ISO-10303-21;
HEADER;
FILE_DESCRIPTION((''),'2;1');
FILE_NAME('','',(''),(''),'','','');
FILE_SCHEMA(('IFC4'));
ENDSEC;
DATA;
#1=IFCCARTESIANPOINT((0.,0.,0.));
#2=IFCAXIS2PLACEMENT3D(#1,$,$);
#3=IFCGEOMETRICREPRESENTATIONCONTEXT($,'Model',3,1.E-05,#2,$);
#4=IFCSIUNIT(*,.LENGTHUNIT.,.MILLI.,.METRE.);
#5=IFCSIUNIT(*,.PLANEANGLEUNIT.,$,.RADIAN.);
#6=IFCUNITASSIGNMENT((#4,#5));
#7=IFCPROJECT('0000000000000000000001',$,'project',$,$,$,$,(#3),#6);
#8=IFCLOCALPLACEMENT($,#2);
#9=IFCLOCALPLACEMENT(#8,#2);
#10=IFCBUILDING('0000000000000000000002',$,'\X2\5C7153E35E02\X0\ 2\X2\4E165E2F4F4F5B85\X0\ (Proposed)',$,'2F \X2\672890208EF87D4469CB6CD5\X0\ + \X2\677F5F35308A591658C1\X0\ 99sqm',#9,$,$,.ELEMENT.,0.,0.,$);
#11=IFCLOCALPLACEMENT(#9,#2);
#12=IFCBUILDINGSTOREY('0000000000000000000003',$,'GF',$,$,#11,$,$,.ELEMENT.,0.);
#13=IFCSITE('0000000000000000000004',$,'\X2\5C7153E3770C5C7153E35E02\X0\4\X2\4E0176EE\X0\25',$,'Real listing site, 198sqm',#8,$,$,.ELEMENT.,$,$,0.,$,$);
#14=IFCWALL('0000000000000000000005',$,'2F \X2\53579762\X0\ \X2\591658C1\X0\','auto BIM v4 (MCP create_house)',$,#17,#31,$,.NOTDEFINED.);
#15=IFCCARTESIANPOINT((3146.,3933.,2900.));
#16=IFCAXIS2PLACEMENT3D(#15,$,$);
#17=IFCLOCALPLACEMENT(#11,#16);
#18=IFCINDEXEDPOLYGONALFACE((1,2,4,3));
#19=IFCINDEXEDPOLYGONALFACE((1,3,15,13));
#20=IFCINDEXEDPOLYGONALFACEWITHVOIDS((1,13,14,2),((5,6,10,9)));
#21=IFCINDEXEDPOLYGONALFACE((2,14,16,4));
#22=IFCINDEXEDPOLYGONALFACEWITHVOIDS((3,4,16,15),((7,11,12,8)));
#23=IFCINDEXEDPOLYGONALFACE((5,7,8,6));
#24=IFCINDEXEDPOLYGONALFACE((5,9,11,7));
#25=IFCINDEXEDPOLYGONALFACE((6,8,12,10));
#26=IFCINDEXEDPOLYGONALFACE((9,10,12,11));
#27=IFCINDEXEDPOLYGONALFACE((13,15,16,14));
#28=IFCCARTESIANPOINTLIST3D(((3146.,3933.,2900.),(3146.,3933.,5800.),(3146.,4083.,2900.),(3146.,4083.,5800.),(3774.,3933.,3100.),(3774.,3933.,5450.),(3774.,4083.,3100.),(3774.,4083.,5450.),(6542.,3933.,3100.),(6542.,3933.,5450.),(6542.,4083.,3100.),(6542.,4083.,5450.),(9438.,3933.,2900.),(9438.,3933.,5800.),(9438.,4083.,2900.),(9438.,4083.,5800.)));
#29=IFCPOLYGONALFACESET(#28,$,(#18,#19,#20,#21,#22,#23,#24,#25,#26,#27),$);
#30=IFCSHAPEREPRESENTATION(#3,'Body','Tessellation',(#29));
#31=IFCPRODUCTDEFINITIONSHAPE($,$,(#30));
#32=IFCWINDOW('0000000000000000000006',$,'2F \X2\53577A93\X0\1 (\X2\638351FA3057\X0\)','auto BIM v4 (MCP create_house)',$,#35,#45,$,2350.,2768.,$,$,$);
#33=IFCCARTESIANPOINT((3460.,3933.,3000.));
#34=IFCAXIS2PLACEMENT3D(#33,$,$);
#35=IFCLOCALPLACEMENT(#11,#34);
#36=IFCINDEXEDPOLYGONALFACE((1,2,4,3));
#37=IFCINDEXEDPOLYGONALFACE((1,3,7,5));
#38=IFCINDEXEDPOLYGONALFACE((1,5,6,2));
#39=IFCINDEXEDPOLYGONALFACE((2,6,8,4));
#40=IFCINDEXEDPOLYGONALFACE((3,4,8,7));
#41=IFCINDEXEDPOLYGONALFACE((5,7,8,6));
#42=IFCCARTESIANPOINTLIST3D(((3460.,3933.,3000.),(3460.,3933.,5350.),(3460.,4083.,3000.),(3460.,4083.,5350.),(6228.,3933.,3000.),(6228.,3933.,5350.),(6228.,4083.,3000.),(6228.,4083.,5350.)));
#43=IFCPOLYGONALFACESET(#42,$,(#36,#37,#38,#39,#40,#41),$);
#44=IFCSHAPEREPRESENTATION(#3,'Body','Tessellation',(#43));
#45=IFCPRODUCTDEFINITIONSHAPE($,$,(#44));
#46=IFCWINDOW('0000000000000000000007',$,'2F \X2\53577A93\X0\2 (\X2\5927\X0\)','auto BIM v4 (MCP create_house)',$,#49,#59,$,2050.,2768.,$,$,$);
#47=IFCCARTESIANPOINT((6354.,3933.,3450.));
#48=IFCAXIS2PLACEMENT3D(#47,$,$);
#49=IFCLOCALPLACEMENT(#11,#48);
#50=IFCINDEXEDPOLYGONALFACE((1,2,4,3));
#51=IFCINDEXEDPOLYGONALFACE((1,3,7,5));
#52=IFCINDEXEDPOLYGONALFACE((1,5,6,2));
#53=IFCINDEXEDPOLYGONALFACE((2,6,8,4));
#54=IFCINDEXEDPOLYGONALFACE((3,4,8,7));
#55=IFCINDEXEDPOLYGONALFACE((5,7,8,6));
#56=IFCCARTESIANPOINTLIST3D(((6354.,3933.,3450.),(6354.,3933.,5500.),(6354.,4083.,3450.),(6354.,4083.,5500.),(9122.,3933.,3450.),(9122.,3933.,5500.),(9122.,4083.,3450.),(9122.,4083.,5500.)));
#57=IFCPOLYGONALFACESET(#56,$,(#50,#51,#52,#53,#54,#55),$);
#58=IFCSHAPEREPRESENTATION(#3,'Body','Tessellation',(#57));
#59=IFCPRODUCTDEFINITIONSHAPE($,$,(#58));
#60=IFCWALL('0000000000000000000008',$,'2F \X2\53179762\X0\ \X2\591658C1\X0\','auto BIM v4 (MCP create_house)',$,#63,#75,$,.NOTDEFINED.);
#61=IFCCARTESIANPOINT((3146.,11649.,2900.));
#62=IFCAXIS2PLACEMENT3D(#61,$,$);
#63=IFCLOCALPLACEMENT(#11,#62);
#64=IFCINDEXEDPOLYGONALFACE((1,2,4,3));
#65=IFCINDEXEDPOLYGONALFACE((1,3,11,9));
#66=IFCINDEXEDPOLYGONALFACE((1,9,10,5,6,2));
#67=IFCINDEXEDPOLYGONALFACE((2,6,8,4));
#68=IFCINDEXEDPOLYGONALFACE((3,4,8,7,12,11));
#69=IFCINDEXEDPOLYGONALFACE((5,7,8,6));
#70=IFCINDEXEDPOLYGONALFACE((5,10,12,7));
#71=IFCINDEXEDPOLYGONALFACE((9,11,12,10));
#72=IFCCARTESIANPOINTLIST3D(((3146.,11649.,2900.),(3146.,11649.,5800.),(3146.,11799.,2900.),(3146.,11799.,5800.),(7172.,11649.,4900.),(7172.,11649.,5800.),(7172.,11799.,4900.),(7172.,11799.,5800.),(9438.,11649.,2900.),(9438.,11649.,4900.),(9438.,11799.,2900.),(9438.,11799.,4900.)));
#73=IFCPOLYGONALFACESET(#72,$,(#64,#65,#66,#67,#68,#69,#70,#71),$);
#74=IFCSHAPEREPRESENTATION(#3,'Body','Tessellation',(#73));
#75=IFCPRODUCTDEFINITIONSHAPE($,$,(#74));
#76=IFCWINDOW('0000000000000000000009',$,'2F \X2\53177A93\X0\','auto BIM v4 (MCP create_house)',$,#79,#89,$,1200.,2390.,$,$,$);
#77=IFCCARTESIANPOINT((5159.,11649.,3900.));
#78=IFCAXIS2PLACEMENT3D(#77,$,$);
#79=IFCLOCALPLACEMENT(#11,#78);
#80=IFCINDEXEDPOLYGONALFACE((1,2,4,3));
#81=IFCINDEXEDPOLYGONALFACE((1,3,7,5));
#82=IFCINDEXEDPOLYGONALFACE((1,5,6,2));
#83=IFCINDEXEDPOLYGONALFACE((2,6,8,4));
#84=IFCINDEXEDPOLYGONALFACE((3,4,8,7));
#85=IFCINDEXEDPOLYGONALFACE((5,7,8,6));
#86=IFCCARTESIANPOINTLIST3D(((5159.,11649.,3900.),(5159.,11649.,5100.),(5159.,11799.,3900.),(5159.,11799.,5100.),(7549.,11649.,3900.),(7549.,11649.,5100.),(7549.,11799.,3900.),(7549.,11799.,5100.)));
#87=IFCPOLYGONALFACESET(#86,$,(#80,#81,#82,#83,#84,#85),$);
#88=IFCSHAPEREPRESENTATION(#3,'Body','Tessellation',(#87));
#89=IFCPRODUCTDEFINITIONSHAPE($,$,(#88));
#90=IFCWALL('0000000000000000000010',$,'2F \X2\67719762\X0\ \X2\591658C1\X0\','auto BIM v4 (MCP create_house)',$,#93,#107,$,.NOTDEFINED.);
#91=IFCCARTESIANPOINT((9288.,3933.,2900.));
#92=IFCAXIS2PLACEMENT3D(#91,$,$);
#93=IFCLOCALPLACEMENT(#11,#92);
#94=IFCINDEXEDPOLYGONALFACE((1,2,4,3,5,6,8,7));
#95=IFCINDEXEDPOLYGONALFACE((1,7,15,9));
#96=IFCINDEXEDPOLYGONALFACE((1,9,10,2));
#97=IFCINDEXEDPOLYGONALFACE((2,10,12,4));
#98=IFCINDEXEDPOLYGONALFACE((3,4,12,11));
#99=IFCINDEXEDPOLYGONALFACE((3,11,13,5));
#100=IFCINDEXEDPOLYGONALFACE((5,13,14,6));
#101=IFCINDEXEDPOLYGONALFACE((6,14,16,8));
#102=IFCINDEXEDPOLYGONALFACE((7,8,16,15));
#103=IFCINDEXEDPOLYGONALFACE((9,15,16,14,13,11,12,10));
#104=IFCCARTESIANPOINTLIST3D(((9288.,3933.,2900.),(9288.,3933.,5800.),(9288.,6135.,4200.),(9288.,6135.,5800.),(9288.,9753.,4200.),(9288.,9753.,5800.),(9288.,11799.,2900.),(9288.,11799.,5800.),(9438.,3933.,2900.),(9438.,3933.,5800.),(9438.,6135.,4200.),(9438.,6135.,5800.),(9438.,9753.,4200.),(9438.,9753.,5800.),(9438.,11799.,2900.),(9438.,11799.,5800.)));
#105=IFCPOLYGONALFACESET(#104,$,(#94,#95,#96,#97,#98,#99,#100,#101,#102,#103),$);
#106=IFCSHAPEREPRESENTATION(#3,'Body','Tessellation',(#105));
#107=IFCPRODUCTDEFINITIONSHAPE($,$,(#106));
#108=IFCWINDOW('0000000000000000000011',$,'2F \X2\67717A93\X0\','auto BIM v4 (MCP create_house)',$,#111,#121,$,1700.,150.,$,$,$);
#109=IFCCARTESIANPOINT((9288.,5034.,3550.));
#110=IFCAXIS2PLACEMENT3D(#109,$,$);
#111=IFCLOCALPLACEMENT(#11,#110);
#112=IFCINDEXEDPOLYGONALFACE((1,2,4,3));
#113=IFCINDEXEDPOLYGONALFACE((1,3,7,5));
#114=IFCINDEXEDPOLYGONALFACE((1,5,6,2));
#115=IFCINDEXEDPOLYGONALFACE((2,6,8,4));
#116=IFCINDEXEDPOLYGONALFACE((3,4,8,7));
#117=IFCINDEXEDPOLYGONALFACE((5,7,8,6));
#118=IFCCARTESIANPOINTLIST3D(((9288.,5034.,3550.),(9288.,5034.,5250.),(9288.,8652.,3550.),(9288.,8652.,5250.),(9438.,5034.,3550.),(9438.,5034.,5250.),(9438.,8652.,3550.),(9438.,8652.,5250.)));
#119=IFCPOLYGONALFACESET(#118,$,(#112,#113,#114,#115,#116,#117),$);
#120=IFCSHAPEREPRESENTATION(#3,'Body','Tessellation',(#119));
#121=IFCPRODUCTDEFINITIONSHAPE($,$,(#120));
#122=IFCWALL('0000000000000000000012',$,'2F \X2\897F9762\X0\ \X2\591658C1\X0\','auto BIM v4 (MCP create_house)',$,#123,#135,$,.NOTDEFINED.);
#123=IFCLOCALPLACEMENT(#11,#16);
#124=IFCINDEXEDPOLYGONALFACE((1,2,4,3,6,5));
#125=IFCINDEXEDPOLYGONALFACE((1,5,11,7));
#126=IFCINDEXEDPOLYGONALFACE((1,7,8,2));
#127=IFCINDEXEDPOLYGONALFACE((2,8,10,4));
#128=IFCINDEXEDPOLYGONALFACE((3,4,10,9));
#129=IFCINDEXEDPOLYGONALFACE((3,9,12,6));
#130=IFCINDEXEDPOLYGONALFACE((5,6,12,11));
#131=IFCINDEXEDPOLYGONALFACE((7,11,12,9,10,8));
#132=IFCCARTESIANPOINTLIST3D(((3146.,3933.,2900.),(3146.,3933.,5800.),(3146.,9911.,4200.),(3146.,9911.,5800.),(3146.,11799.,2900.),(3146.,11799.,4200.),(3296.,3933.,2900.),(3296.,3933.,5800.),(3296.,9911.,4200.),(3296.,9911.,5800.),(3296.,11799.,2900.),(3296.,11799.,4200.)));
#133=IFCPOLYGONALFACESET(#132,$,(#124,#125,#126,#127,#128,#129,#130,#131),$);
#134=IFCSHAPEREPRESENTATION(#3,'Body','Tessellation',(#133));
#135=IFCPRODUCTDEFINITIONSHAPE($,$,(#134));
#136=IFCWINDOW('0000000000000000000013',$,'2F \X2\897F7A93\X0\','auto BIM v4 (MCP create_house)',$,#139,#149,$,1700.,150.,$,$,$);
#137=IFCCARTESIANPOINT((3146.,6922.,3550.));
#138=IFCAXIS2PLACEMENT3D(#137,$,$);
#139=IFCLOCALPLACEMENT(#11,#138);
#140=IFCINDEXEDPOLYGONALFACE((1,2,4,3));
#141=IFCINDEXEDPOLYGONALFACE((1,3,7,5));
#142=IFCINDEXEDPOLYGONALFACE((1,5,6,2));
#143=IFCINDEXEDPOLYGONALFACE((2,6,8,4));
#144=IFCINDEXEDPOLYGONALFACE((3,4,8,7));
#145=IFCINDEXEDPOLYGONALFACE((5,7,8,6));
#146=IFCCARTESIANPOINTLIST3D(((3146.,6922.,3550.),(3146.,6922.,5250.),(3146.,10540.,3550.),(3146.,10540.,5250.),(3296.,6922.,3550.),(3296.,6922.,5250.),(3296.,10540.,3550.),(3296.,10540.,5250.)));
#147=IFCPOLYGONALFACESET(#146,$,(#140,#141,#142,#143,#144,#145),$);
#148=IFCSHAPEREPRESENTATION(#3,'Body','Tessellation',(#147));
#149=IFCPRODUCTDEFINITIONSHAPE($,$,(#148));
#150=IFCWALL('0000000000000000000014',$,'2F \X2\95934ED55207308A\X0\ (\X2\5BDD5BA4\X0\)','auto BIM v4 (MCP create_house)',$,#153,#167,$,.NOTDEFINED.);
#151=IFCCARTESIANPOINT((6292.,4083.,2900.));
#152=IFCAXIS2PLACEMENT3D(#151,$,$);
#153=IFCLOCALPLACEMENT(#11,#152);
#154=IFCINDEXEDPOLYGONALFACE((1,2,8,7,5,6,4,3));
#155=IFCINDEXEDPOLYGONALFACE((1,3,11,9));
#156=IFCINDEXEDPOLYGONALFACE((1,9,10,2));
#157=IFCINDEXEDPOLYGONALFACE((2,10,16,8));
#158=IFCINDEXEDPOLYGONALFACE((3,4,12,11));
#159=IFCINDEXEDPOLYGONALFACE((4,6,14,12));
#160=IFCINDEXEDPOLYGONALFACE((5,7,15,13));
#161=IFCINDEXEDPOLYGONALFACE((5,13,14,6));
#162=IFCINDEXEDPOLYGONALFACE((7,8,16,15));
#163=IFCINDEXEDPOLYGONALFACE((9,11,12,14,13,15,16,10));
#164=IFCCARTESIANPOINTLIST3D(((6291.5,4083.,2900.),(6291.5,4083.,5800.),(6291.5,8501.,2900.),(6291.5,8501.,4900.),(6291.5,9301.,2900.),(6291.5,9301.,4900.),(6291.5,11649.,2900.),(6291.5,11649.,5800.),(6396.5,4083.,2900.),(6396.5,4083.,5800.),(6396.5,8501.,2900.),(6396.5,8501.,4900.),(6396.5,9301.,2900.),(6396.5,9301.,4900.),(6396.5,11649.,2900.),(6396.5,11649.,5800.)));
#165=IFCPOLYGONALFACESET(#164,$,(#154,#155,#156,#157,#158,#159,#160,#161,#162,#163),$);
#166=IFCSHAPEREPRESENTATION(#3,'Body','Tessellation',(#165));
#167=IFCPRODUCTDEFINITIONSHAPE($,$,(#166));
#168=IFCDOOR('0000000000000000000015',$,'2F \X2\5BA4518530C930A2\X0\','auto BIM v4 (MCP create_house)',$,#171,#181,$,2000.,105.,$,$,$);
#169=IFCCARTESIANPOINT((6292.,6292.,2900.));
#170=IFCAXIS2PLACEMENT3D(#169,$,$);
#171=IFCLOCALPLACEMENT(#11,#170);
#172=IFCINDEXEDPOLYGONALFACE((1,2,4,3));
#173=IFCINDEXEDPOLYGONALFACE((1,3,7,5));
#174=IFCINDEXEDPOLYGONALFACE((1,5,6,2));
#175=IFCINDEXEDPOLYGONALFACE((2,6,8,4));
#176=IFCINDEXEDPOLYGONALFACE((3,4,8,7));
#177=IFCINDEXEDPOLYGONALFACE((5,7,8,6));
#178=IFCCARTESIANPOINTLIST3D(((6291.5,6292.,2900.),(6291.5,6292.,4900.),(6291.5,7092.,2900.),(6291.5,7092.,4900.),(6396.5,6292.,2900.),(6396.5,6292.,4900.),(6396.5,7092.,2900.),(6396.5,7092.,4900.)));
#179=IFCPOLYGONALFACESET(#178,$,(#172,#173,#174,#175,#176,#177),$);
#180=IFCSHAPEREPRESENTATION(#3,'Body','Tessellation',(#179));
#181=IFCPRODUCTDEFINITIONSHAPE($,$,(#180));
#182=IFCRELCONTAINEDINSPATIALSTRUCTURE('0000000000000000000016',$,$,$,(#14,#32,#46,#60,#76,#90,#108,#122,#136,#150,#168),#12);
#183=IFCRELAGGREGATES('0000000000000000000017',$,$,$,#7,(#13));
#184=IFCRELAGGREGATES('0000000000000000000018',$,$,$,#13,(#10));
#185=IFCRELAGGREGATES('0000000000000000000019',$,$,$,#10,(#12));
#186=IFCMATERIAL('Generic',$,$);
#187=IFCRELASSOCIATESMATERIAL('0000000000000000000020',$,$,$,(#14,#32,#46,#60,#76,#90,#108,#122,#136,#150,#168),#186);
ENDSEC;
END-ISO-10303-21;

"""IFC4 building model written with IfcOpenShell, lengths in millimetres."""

from ifc_helpers import new_model, si_unit, frame, frame_2d, origin, place, context, project, spatial, rectangle, extrude, material, element, fill, save


model = new_model("IFC4")

# Units and contexts
model_context = context("Model", 3, precision=1e-05, world=origin())
ifc_project = project(units=[si_unit("LENGTHUNIT", "METRE", prefix="MILLI"), si_unit("PLANEANGLEUNIT", "RADIAN")], contexts=[model_context])

# Site, building, storey
site_placement = place(None, origin())
site = spatial("IfcSite", under=ifc_project, at=site_placement, Name="山口県山口市4丁目25", ObjectType="Real listing site, 198sqm", CompositionType="ELEMENT", RefElevation=0.0)
building_placement = place(site_placement, origin())
building = spatial("IfcBuilding", under=site, at=building_placement, Name="山口市 2世帯住宅 (Proposed)", ObjectType="2F 木造軸組構法 + 板張り外壁 99sqm", CompositionType="ELEMENT", ElevationOfRefHeight=0.0, ElevationOfTerrain=0.0)
storey_placement = place(building_placement, origin())
storey = spatial("IfcBuildingStorey", under=building, at=storey_placement, Name="GF", CompositionType="ELEMENT", Elevation=0.0)

# Shared definitions
ifc_material = material(Name="Generic")

# Wall, openings, windows
wall_1_placement = place(storey_placement, frame((3146.0, 3933.0, 2900.0)))
wall_1 = element("IfcWall", 1, at=wall_1_placement, inside=storey, material=ifc_material, Name="2F 南面 外壁", Description="auto BIM v4 (MCP create_house)", PredefinedType="NOTDEFINED", context=model_context, shape_type="SweptSolid", body=[
    extrude(rectangle(XDim=6292.0, YDim=150.0, at=frame_2d((3146.0, 75.0))), frame((3146.0, 3933.0, 2900.0)), (0.0, 0.0, 1.0), 2900.0),
])
opening_1_placement = place(storey_placement, frame((3460.0, 3933.0, 3000.0)))
opening_1 = element("IfcOpeningElement", 2, at=opening_1_placement, cuts=wall_1, PredefinedType="NOTDEFINED", context=model_context, shape_type="SweptSolid", body=[
    extrude(rectangle(XDim=2768.0, YDim=150.0, at=frame_2d((1384.0, 75.0))), frame((3460.0, 3933.0, 3000.0)), (0.0, 0.0, 1.0), 2350.0),
])
opening_2_placement = place(storey_placement, frame((6354.0, 3933.0, 3450.0)))
opening_2 = element("IfcOpeningElement", 3, at=opening_2_placement, cuts=wall_1, PredefinedType="NOTDEFINED", context=model_context, shape_type="SweptSolid", body=[
    extrude(rectangle(XDim=2768.0, YDim=150.0, at=frame_2d((1384.0, 75.0))), frame((6354.0, 3933.0, 3450.0)), (0.0, 0.0, 1.0), 2050.0),
])
window_1_placement = place(storey_placement, frame((3460.0, 3933.0, 3000.0)))
window_1 = element("IfcWindow", 4, at=window_1_placement, inside=storey, material=ifc_material, Name="2F 南窓1 (掃出し)", Description="auto BIM v4 (MCP create_house)", OverallHeight=2350.0, OverallWidth=2768.0, context=model_context, shape_type="SweptSolid", body=[
    extrude(rectangle(XDim=2768.0, YDim=150.0, at=frame_2d((1384.0, 75.0))), frame((3460.0, 3933.0, 3000.0)), (0.0, 0.0, 1.0), 2350.0),
])
fill(opening_1, window_1)
window_2_placement = place(storey_placement, frame((6354.0, 3933.0, 3450.0)))
window_2 = element("IfcWindow", 5, at=window_2_placement, inside=storey, material=ifc_material, Name="2F 南窓2 (大)", Description="auto BIM v4 (MCP create_house)", OverallHeight=2050.0, OverallWidth=2768.0, context=model_context, shape_type="SweptSolid", body=[
    extrude(rectangle(XDim=2768.0, YDim=150.0, at=frame_2d((1384.0, 75.0))), frame((6354.0, 3933.0, 3450.0)), (0.0, 0.0, 1.0), 2050.0),
])
fill(opening_2, window_2)

# Walls, openings, windows
wall_2_placement = place(storey_placement, frame((3146.0, 11649.0, 2900.0)))
wall_2 = element("IfcWall", 6, at=wall_2_placement, inside=storey, material=ifc_material, Name="2F 北面 外壁", Description="auto BIM v4 (MCP create_house)", PredefinedType="NOTDEFINED", context=model_context, shape_type="SweptSolid", body=[
    extrude(rectangle(XDim=6292.0, YDim=150.0, at=frame_2d((3146.0, 75.0))), frame((3146.0, 11649.0, 2900.0)), (0.0, 0.0, 1.0), 2900.0),
])
opening_3_placement = place(storey_placement, frame((5159.0, 11649.0, 3900.0)))
opening_3 = element("IfcOpeningElement", 7, at=opening_3_placement, cuts=wall_2, PredefinedType="NOTDEFINED", context=model_context, shape_type="SweptSolid", body=[
    extrude(rectangle(XDim=2390.0, YDim=150.0, at=frame_2d((1195.0, 75.0))), frame((5159.0, 11649.0, 3900.0)), (0.0, 0.0, 1.0), 1200.0),
])
window_3_placement = place(storey_placement, frame((5159.0, 11649.0, 3900.0)))
window_3 = element("IfcWindow", 8, at=window_3_placement, inside=storey, material=ifc_material, Name="2F 北窓", Description="auto BIM v4 (MCP create_house)", OverallHeight=1200.0, OverallWidth=2390.0, context=model_context, shape_type="SweptSolid", body=[
    extrude(rectangle(XDim=2390.0, YDim=150.0, at=frame_2d((1195.0, 75.0))), frame((5159.0, 11649.0, 3900.0)), (0.0, 0.0, 1.0), 1200.0),
])
fill(opening_3, window_3)
wall_3_placement = place(storey_placement, frame((9288.0, 3933.0, 2900.0)))
wall_3 = element("IfcWall", 9, at=wall_3_placement, inside=storey, material=ifc_material, Name="2F 東面 外壁", Description="auto BIM v4 (MCP create_house)", PredefinedType="NOTDEFINED", context=model_context, shape_type="SweptSolid", body=[
    extrude(rectangle(XDim=150.0, YDim=7866.0, at=frame_2d((75.0, 3933.0))), frame((9288.0, 3933.0, 2900.0)), (0.0, 0.0, 1.0), 2900.0),
])
opening_4_placement = place(storey_placement, frame((9288.0, 5034.0, 3550.0)))
opening_4 = element("IfcOpeningElement", 10, at=opening_4_placement, cuts=wall_3, PredefinedType="NOTDEFINED", context=model_context, shape_type="SweptSolid", body=[
    extrude(rectangle(XDim=150.0, YDim=3618.0, at=frame_2d((75.0, 1809.0))), frame((9288.0, 5034.0, 3550.0)), (0.0, 0.0, 1.0), 1700.0),
])
window_4_placement = place(storey_placement, frame((9288.0, 5034.0, 3550.0)))
window_4 = element("IfcWindow", 11, at=window_4_placement, inside=storey, material=ifc_material, Name="2F 東窓", Description="auto BIM v4 (MCP create_house)", OverallHeight=1700.0, OverallWidth=150.0, context=model_context, shape_type="SweptSolid", body=[
    extrude(rectangle(XDim=150.0, YDim=3618.0, at=frame_2d((75.0, 1809.0))), frame((9288.0, 5034.0, 3550.0)), (0.0, 0.0, 1.0), 1700.0),
])
fill(opening_4, window_4)
wall_4_placement = place(storey_placement, frame((3146.0, 3933.0, 2900.0)))
wall_4 = element("IfcWall", 12, at=wall_4_placement, inside=storey, material=ifc_material, Name="2F 西面 外壁", Description="auto BIM v4 (MCP create_house)", PredefinedType="NOTDEFINED", context=model_context, shape_type="SweptSolid", body=[
    extrude(rectangle(XDim=150.0, YDim=7866.0, at=frame_2d((75.0, 3933.0))), frame((3146.0, 3933.0, 2900.0)), (0.0, 0.0, 1.0), 2900.0),
])
opening_5_placement = place(storey_placement, frame((3146.0, 6922.0, 3550.0)))
opening_5 = element("IfcOpeningElement", 13, at=opening_5_placement, cuts=wall_4, PredefinedType="NOTDEFINED", context=model_context, shape_type="SweptSolid", body=[
    extrude(rectangle(XDim=150.0, YDim=3618.0, at=frame_2d((75.0, 1809.0))), frame((3146.0, 6922.0, 3550.0)), (0.0, 0.0, 1.0), 1700.0),
])
window_5_placement = place(storey_placement, frame((3146.0, 6922.0, 3550.0)))
window_5 = element("IfcWindow", 14, at=window_5_placement, inside=storey, material=ifc_material, Name="2F 西窓", Description="auto BIM v4 (MCP create_house)", OverallHeight=1700.0, OverallWidth=150.0, context=model_context, shape_type="SweptSolid", body=[
    extrude(rectangle(XDim=150.0, YDim=3618.0, at=frame_2d((75.0, 1809.0))), frame((3146.0, 6922.0, 3550.0)), (0.0, 0.0, 1.0), 1700.0),
])
fill(opening_5, window_5)

# Wall, opening, door
wall_5_placement = place(storey_placement, frame((6292.0, 4083.0, 2900.0)))
wall_5 = element("IfcWall", 15, at=wall_5_placement, inside=storey, material=ifc_material, Name="2F 間仕切り (寝室)", Description="auto BIM v4 (MCP create_house)", PredefinedType="NOTDEFINED", context=model_context, shape_type="SweptSolid", body=[
    extrude(rectangle(XDim=105.0, YDim=7566.0, at=frame_2d((52.0, 3783.0))), frame((6292.0, 4083.0, 2900.0)), (0.0, 0.0, 1.0), 2900.0),
])
opening_6_placement = place(storey_placement, frame((6292.0, 6292.0, 2900.0)))
opening_6 = element("IfcOpeningElement", 16, at=opening_6_placement, cuts=wall_5, PredefinedType="NOTDEFINED", context=model_context, shape_type="SweptSolid", body=[
    extrude(rectangle(XDim=105.0, YDim=800.0, at=frame_2d((52.0, 400.0))), frame((6292.0, 6292.0, 2900.0)), (0.0, 0.0, 1.0), 2000.0),
])
door_1_placement = place(storey_placement, frame((6292.0, 6292.0, 2900.0)))
door_1 = element("IfcDoor", 17, at=door_1_placement, inside=storey, material=ifc_material, Name="2F 室内ドア", Description="auto BIM v4 (MCP create_house)", OverallHeight=2000.0, OverallWidth=105.0, context=model_context, shape_type="SweptSolid", body=[
    extrude(rectangle(XDim=105.0, YDim=800.0, at=frame_2d((52.0, 400.0))), frame((6292.0, 6292.0, 2900.0)), (0.0, 0.0, 1.0), 2000.0),
])
fill(opening_6, door_1)

save(model, "model.ifc")
